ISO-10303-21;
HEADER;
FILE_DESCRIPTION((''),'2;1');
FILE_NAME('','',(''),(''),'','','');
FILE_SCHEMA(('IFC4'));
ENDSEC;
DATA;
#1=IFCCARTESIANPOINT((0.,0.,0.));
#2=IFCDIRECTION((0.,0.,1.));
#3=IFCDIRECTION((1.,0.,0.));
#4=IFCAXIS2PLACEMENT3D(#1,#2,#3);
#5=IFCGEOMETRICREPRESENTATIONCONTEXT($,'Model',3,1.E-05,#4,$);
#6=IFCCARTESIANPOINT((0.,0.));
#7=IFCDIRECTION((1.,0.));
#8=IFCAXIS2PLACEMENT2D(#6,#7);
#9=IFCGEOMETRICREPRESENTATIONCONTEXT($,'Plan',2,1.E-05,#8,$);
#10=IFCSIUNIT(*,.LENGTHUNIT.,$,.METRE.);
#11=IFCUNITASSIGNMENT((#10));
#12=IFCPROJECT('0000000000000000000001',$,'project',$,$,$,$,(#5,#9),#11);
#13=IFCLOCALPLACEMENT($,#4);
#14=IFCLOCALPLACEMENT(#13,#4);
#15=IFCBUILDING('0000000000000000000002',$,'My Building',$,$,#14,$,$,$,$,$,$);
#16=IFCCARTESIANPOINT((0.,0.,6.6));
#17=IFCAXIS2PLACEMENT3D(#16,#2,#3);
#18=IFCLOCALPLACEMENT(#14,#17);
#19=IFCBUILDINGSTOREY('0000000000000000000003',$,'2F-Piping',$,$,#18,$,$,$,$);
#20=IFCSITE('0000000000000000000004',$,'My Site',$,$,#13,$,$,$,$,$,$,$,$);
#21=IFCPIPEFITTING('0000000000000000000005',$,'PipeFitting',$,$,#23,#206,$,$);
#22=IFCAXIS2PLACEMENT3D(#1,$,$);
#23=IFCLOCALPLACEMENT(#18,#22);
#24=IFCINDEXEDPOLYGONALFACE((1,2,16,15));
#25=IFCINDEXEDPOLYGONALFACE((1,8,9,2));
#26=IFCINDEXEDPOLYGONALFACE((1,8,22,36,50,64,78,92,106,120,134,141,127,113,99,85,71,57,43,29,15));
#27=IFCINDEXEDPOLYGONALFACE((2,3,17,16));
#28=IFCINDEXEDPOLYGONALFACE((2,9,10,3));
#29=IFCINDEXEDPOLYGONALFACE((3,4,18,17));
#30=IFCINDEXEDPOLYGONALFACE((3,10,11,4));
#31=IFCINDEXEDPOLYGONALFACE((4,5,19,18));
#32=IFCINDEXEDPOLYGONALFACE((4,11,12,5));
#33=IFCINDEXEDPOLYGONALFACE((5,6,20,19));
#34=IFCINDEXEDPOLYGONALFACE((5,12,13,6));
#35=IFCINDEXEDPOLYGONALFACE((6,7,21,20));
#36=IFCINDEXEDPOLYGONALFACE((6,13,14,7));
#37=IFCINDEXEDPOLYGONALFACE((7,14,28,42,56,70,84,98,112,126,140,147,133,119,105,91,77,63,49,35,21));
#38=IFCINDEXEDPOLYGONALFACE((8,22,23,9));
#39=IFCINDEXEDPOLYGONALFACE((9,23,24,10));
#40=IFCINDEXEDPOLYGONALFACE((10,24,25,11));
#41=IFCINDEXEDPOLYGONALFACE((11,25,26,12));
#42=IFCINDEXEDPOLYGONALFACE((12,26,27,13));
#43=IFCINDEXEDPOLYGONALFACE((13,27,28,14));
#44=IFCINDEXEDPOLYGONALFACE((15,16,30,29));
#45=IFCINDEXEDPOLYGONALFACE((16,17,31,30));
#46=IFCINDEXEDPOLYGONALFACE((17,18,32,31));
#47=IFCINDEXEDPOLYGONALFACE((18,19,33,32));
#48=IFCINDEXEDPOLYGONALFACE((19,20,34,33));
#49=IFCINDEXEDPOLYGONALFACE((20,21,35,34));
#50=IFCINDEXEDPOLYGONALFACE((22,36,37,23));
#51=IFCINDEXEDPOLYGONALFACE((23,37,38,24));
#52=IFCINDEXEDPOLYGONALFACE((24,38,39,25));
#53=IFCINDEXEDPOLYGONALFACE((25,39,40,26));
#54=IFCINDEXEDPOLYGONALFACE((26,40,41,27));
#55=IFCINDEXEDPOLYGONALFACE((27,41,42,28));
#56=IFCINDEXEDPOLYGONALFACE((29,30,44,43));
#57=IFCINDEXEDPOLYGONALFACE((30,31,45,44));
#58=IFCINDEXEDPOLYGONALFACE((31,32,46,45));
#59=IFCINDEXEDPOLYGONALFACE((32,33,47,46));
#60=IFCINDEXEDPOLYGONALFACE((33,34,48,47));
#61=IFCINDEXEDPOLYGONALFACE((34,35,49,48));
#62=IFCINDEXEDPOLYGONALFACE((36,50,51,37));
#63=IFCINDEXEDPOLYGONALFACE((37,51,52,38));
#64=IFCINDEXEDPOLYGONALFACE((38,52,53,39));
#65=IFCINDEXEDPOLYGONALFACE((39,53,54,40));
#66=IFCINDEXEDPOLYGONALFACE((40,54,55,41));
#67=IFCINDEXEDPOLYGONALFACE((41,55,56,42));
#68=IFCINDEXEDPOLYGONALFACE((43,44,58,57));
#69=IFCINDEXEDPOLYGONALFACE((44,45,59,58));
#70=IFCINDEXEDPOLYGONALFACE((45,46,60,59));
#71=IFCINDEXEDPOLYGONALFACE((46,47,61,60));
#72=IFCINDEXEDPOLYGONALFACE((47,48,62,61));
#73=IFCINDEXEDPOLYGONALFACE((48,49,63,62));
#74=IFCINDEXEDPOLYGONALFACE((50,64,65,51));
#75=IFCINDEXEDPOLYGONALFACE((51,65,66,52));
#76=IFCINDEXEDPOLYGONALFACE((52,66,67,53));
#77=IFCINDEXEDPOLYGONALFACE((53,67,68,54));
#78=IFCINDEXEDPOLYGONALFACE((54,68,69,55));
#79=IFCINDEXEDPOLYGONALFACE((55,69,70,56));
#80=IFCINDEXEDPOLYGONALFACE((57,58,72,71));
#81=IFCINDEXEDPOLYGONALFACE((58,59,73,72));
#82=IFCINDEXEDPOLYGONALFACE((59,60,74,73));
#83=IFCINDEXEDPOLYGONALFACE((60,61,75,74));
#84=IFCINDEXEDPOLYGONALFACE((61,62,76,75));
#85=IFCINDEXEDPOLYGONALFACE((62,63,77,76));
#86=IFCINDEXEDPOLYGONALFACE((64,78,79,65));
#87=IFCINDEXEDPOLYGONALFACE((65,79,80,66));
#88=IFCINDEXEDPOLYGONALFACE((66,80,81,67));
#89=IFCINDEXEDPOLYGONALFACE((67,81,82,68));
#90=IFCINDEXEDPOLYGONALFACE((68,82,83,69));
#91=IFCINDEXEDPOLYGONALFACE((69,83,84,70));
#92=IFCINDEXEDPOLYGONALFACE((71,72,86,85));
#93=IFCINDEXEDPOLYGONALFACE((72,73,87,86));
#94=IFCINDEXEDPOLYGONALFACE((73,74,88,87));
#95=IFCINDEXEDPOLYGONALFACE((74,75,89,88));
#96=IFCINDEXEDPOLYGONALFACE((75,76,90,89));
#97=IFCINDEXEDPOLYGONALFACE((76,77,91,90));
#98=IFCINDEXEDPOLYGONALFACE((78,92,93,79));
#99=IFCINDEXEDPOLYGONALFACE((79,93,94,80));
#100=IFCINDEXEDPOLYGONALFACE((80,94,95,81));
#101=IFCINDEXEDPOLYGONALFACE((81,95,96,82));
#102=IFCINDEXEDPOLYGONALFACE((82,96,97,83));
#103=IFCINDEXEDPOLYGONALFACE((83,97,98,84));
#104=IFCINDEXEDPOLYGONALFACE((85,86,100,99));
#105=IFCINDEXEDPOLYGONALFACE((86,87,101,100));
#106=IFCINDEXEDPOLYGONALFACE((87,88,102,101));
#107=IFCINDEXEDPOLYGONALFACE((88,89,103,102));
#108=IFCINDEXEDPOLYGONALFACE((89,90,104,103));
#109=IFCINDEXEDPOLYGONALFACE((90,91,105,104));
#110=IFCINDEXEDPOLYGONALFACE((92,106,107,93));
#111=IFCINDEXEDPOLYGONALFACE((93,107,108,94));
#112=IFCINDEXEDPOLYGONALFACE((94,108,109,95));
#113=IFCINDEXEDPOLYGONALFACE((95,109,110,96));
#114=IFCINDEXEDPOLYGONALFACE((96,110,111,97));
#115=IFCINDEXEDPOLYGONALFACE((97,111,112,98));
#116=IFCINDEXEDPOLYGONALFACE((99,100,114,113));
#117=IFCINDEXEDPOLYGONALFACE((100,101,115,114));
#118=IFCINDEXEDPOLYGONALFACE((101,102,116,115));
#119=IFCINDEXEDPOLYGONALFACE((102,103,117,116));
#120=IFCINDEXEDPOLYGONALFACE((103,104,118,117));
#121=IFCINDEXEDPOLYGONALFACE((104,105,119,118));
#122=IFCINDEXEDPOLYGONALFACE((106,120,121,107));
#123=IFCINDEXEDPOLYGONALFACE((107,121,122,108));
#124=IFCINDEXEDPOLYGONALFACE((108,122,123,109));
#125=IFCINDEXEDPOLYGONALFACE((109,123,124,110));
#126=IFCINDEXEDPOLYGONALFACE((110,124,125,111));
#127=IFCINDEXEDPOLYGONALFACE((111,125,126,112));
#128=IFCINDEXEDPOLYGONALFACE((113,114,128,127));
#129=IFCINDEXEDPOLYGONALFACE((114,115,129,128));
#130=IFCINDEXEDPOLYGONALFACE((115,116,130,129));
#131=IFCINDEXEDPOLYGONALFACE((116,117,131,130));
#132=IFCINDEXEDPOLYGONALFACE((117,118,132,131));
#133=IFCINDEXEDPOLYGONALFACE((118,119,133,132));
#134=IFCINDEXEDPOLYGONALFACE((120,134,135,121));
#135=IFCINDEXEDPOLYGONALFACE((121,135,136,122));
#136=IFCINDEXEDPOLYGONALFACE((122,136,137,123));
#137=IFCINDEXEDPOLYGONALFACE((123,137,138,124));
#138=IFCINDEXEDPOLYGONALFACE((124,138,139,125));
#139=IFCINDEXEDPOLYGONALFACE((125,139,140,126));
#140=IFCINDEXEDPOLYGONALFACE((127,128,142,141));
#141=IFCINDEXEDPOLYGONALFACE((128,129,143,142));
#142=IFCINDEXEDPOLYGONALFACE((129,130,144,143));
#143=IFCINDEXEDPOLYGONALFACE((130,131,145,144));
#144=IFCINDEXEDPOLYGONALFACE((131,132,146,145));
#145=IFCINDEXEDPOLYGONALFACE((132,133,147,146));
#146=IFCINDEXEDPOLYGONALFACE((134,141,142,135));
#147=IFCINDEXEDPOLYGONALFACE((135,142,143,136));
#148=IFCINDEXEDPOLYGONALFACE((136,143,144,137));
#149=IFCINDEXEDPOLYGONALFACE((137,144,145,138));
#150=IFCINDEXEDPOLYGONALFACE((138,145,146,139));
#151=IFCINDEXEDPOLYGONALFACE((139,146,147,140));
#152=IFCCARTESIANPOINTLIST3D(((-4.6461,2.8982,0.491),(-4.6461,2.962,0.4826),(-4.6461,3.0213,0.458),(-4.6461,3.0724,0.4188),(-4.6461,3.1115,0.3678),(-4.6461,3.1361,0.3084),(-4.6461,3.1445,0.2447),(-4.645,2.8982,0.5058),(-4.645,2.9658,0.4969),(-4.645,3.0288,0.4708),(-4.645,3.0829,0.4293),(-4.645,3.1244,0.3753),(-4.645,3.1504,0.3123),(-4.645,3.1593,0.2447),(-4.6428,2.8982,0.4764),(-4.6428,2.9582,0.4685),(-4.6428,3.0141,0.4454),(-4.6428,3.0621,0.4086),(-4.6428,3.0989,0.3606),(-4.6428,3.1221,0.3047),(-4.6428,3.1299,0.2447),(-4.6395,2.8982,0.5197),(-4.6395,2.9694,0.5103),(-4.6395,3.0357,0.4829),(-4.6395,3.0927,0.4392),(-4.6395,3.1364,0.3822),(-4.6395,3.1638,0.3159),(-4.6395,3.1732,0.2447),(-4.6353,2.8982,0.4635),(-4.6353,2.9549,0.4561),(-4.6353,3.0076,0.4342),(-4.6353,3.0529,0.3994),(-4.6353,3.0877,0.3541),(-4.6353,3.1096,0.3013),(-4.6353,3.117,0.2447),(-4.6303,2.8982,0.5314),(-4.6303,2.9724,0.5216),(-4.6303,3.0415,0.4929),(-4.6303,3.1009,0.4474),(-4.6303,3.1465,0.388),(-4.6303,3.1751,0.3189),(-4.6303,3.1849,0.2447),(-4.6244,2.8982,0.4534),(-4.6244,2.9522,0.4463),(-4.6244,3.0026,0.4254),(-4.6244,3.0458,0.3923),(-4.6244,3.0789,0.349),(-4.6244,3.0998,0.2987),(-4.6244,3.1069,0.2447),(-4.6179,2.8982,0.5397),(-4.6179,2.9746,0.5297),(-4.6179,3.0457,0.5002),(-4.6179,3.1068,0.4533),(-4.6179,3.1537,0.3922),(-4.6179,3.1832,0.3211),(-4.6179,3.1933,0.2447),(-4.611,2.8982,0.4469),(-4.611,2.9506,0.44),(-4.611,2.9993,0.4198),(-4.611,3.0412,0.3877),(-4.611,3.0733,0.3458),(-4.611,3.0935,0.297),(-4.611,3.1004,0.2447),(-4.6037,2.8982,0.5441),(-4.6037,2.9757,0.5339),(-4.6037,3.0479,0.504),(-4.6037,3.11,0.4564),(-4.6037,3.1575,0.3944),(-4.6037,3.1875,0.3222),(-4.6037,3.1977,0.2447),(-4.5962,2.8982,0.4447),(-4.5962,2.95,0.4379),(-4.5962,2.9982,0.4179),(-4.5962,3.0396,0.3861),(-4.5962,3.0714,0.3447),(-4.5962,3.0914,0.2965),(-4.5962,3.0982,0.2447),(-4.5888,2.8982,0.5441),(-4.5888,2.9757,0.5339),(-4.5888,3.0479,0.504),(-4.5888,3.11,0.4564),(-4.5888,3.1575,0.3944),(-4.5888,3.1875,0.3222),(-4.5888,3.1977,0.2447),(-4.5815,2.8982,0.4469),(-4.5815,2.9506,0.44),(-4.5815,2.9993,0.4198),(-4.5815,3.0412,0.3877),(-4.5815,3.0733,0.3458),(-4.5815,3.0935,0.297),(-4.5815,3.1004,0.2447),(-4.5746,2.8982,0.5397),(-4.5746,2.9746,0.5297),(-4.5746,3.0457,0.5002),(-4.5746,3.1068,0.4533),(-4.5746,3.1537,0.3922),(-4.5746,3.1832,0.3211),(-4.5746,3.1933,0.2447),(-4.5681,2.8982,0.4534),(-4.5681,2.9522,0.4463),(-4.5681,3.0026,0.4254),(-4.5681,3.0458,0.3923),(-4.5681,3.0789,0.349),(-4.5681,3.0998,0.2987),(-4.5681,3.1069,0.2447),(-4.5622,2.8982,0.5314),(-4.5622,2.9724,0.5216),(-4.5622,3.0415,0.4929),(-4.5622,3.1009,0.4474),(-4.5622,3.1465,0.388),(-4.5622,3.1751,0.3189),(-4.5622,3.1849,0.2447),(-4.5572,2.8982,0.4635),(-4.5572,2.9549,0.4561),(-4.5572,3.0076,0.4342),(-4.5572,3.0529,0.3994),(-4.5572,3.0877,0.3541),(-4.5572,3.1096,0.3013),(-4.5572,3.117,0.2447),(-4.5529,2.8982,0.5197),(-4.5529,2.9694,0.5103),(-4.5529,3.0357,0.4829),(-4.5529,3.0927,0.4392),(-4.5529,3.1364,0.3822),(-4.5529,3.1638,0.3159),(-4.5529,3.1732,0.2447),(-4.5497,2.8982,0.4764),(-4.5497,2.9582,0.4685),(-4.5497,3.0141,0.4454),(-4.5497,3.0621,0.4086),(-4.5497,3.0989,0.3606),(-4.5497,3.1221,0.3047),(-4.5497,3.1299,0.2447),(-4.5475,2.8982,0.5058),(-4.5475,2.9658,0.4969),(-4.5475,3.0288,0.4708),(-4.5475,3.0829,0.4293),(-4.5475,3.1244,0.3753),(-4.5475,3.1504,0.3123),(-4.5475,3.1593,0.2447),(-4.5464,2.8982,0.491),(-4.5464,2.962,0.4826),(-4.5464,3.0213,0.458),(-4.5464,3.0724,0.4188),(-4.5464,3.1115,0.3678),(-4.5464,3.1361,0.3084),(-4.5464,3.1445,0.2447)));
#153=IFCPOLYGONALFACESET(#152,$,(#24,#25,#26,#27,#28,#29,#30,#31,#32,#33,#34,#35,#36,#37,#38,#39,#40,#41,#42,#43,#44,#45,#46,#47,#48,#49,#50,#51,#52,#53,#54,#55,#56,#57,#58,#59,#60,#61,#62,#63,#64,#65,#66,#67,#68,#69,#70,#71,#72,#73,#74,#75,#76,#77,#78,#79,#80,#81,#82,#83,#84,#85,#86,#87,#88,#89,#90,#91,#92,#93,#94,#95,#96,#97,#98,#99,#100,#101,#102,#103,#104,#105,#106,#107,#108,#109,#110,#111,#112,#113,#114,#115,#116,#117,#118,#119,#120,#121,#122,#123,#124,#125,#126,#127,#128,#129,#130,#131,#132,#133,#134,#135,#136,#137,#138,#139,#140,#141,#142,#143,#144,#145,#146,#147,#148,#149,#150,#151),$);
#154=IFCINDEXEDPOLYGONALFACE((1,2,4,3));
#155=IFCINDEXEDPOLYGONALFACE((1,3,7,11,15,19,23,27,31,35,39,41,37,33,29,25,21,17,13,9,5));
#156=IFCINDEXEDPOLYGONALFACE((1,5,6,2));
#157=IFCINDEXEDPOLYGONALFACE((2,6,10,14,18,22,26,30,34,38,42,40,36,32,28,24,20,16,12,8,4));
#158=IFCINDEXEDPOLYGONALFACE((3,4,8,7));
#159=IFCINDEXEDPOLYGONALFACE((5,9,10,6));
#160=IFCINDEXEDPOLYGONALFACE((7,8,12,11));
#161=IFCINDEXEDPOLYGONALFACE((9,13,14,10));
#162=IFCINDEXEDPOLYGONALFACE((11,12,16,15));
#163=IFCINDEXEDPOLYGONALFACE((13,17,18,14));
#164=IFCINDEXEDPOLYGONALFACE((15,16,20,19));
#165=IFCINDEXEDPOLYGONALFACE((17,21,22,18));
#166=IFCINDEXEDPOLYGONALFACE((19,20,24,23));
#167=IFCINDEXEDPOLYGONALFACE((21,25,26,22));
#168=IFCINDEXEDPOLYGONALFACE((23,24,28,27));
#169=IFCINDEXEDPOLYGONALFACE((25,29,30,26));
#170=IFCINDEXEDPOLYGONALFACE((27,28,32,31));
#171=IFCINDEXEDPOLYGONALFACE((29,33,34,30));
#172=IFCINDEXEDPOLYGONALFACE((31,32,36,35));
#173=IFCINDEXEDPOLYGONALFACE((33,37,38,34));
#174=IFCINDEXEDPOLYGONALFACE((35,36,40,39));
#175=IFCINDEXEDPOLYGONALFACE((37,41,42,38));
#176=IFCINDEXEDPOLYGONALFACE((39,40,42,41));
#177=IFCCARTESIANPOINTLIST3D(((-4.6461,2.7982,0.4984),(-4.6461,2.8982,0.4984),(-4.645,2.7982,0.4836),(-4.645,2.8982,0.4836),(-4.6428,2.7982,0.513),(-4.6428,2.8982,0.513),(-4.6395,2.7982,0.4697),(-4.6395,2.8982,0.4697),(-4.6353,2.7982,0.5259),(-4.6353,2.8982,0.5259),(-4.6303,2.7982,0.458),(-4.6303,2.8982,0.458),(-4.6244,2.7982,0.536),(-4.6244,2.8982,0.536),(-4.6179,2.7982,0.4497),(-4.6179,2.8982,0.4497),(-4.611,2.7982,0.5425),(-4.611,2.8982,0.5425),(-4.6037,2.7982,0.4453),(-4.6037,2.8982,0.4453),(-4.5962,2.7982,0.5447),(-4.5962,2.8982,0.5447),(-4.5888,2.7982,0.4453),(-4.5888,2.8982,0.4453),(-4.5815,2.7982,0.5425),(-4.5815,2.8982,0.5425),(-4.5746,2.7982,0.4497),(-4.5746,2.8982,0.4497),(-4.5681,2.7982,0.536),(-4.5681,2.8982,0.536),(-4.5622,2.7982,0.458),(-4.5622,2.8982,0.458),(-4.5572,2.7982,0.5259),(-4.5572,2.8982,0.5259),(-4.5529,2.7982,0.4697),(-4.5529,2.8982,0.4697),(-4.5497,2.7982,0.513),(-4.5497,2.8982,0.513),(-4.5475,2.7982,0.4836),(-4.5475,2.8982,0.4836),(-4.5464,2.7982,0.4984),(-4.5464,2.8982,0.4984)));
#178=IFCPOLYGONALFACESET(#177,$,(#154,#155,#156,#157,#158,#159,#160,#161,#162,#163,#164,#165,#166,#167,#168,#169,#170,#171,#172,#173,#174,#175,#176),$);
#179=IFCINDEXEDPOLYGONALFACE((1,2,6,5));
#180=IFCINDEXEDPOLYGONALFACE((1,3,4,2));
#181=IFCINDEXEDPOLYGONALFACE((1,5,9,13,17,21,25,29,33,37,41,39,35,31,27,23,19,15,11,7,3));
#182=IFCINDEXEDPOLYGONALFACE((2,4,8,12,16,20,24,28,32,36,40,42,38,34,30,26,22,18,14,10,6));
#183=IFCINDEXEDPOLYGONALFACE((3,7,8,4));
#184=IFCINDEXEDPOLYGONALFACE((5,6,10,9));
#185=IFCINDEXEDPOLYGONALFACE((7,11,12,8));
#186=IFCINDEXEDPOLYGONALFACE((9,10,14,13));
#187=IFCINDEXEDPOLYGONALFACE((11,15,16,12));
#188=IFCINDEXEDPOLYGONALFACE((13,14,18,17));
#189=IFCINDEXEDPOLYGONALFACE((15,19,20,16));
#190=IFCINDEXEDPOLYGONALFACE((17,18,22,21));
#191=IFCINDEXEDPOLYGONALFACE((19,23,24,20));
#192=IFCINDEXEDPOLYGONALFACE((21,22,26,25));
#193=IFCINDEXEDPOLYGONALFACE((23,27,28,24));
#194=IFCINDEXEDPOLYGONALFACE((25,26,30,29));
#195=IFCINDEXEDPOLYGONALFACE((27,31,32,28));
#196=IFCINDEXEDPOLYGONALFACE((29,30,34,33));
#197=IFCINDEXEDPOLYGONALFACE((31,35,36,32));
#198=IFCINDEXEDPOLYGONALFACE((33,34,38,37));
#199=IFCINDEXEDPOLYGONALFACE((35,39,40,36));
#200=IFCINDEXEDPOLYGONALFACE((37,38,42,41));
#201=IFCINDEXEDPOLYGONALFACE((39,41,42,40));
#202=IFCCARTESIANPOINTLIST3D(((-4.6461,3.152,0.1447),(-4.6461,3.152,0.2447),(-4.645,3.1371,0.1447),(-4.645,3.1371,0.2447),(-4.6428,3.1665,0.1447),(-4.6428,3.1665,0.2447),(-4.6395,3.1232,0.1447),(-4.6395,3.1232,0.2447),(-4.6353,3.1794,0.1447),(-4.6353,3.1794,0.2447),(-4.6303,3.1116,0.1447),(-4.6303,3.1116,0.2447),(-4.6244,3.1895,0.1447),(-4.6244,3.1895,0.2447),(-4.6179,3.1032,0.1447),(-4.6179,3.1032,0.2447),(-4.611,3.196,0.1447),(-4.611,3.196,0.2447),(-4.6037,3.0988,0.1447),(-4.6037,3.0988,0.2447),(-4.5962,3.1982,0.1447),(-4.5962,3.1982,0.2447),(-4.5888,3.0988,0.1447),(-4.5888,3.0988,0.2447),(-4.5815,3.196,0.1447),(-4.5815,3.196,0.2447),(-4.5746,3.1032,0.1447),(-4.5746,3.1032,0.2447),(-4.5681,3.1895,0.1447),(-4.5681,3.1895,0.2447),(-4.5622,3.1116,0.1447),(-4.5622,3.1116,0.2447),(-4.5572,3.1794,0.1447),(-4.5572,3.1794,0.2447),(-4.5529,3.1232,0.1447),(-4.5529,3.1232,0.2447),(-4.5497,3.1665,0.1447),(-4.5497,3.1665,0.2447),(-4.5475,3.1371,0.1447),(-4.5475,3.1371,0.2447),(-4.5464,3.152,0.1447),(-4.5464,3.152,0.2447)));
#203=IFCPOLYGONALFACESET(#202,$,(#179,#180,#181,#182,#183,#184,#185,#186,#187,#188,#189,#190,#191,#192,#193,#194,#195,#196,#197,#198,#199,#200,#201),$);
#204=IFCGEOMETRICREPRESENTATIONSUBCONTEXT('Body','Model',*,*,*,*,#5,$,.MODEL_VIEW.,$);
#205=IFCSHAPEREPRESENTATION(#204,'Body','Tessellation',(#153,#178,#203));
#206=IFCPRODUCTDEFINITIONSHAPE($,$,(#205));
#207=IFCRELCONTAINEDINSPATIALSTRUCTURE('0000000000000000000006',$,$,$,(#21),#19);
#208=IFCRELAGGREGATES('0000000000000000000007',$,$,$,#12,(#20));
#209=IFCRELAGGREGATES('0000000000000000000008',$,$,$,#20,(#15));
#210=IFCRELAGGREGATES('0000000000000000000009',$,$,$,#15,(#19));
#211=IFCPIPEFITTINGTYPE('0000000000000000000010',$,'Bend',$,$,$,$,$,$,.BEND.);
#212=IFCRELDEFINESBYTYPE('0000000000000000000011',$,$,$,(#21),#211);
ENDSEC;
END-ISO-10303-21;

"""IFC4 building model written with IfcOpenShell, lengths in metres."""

from ifc_helpers import new_model, entity, si_unit, frame, origin_with_axes, origin_2d_with_axis, place, context, subcontext, project, spatial, circle, extrude, source, transform, mapped, type_object, type_shapes, element, save


model = new_model("IFC4")

# Units and contexts
model_context = context("Model", 3, precision=1e-05, world=origin_with_axes())
plan_context = context("Plan", 2, precision=1e-05, world=origin_2d_with_axis())
body_context = subcontext(model_context, "Body", "Model", "MODEL_VIEW")
ifc_project = project(units=[si_unit("LENGTHUNIT", "METRE")], contexts=[model_context, plan_context])

# Site, building, storey
site_placement = place(None, origin_with_axes())
site = spatial("IfcSite", under=ifc_project, at=site_placement, Name="My Site")
building_placement = place(site_placement, origin_with_axes())
building = spatial("IfcBuilding", under=site, at=building_placement, Name="My Building")
storey_placement = place(building_placement, frame((0.0, 0.0, 6.6), z_axis=(0.0, 0.0, 1.0), x_axis=(1.0, 0.0, 0.0)))
storey = spatial("IfcBuildingStorey", under=building, at=storey_placement, Name="2F-Piping")

# Pipe fitting
pipe_fitting_type = type_object("IfcPipeFittingType", Name="Bend", PredefinedType="BEND")
shared_shape = source(origin_with_axes(), body_context, "Body", "SolidModel", [
    entity("IfcSweptDiskSolid", entity("IfcIndexedPolyCurve", entity("IfcCartesianPointList3D", [[0.0, 0.0, -0.1], [-0.0732, 0.0, -0.2768], [-0.25, 0.0, -0.35]]), [entity("IfcArcIndex", [1, 2, 3])]), 0.05),
    extrude(circle(Radius=0.05), origin_with_axes(), (0.0, 0.0, -1.0), 0.1),
    extrude(circle(Radius=0.05), frame((-0.25, 0.0, -0.35), z_axis=(-1.0, 0.0, 0.0), x_axis=(0.0, 0.0, -1.0)), (0.0, 0.0, 1.0), 0.1),
])
type_shapes(pipe_fitting_type, [shared_shape])
for number, where, z_axis, x_axis, name in (
    (1, (-4.5962, 2.7982, 0.4947), (0.0, -1.0, 0.0), (0.0, 0.0, 1.0), "PipeFitting"),
):
    element("IfcPipeFitting", number, at=place(storey_placement, frame(where, z_axis=z_axis, x_axis=x_axis)), inside=storey, type_object=pipe_fitting_type, Name=name, context=body_context, shape_type="MappedRepresentation", body=[
        mapped(shared_shape, transform((0.0, 0.0, 0.0), x_axis=(1.0, 0.0, 0.0), y_axis=(0.0, 1.0, 0.0), z_axis=(0.0, 0.0, 1.0), scale=1.0)),
    ])

save(model, "model.ifc")
